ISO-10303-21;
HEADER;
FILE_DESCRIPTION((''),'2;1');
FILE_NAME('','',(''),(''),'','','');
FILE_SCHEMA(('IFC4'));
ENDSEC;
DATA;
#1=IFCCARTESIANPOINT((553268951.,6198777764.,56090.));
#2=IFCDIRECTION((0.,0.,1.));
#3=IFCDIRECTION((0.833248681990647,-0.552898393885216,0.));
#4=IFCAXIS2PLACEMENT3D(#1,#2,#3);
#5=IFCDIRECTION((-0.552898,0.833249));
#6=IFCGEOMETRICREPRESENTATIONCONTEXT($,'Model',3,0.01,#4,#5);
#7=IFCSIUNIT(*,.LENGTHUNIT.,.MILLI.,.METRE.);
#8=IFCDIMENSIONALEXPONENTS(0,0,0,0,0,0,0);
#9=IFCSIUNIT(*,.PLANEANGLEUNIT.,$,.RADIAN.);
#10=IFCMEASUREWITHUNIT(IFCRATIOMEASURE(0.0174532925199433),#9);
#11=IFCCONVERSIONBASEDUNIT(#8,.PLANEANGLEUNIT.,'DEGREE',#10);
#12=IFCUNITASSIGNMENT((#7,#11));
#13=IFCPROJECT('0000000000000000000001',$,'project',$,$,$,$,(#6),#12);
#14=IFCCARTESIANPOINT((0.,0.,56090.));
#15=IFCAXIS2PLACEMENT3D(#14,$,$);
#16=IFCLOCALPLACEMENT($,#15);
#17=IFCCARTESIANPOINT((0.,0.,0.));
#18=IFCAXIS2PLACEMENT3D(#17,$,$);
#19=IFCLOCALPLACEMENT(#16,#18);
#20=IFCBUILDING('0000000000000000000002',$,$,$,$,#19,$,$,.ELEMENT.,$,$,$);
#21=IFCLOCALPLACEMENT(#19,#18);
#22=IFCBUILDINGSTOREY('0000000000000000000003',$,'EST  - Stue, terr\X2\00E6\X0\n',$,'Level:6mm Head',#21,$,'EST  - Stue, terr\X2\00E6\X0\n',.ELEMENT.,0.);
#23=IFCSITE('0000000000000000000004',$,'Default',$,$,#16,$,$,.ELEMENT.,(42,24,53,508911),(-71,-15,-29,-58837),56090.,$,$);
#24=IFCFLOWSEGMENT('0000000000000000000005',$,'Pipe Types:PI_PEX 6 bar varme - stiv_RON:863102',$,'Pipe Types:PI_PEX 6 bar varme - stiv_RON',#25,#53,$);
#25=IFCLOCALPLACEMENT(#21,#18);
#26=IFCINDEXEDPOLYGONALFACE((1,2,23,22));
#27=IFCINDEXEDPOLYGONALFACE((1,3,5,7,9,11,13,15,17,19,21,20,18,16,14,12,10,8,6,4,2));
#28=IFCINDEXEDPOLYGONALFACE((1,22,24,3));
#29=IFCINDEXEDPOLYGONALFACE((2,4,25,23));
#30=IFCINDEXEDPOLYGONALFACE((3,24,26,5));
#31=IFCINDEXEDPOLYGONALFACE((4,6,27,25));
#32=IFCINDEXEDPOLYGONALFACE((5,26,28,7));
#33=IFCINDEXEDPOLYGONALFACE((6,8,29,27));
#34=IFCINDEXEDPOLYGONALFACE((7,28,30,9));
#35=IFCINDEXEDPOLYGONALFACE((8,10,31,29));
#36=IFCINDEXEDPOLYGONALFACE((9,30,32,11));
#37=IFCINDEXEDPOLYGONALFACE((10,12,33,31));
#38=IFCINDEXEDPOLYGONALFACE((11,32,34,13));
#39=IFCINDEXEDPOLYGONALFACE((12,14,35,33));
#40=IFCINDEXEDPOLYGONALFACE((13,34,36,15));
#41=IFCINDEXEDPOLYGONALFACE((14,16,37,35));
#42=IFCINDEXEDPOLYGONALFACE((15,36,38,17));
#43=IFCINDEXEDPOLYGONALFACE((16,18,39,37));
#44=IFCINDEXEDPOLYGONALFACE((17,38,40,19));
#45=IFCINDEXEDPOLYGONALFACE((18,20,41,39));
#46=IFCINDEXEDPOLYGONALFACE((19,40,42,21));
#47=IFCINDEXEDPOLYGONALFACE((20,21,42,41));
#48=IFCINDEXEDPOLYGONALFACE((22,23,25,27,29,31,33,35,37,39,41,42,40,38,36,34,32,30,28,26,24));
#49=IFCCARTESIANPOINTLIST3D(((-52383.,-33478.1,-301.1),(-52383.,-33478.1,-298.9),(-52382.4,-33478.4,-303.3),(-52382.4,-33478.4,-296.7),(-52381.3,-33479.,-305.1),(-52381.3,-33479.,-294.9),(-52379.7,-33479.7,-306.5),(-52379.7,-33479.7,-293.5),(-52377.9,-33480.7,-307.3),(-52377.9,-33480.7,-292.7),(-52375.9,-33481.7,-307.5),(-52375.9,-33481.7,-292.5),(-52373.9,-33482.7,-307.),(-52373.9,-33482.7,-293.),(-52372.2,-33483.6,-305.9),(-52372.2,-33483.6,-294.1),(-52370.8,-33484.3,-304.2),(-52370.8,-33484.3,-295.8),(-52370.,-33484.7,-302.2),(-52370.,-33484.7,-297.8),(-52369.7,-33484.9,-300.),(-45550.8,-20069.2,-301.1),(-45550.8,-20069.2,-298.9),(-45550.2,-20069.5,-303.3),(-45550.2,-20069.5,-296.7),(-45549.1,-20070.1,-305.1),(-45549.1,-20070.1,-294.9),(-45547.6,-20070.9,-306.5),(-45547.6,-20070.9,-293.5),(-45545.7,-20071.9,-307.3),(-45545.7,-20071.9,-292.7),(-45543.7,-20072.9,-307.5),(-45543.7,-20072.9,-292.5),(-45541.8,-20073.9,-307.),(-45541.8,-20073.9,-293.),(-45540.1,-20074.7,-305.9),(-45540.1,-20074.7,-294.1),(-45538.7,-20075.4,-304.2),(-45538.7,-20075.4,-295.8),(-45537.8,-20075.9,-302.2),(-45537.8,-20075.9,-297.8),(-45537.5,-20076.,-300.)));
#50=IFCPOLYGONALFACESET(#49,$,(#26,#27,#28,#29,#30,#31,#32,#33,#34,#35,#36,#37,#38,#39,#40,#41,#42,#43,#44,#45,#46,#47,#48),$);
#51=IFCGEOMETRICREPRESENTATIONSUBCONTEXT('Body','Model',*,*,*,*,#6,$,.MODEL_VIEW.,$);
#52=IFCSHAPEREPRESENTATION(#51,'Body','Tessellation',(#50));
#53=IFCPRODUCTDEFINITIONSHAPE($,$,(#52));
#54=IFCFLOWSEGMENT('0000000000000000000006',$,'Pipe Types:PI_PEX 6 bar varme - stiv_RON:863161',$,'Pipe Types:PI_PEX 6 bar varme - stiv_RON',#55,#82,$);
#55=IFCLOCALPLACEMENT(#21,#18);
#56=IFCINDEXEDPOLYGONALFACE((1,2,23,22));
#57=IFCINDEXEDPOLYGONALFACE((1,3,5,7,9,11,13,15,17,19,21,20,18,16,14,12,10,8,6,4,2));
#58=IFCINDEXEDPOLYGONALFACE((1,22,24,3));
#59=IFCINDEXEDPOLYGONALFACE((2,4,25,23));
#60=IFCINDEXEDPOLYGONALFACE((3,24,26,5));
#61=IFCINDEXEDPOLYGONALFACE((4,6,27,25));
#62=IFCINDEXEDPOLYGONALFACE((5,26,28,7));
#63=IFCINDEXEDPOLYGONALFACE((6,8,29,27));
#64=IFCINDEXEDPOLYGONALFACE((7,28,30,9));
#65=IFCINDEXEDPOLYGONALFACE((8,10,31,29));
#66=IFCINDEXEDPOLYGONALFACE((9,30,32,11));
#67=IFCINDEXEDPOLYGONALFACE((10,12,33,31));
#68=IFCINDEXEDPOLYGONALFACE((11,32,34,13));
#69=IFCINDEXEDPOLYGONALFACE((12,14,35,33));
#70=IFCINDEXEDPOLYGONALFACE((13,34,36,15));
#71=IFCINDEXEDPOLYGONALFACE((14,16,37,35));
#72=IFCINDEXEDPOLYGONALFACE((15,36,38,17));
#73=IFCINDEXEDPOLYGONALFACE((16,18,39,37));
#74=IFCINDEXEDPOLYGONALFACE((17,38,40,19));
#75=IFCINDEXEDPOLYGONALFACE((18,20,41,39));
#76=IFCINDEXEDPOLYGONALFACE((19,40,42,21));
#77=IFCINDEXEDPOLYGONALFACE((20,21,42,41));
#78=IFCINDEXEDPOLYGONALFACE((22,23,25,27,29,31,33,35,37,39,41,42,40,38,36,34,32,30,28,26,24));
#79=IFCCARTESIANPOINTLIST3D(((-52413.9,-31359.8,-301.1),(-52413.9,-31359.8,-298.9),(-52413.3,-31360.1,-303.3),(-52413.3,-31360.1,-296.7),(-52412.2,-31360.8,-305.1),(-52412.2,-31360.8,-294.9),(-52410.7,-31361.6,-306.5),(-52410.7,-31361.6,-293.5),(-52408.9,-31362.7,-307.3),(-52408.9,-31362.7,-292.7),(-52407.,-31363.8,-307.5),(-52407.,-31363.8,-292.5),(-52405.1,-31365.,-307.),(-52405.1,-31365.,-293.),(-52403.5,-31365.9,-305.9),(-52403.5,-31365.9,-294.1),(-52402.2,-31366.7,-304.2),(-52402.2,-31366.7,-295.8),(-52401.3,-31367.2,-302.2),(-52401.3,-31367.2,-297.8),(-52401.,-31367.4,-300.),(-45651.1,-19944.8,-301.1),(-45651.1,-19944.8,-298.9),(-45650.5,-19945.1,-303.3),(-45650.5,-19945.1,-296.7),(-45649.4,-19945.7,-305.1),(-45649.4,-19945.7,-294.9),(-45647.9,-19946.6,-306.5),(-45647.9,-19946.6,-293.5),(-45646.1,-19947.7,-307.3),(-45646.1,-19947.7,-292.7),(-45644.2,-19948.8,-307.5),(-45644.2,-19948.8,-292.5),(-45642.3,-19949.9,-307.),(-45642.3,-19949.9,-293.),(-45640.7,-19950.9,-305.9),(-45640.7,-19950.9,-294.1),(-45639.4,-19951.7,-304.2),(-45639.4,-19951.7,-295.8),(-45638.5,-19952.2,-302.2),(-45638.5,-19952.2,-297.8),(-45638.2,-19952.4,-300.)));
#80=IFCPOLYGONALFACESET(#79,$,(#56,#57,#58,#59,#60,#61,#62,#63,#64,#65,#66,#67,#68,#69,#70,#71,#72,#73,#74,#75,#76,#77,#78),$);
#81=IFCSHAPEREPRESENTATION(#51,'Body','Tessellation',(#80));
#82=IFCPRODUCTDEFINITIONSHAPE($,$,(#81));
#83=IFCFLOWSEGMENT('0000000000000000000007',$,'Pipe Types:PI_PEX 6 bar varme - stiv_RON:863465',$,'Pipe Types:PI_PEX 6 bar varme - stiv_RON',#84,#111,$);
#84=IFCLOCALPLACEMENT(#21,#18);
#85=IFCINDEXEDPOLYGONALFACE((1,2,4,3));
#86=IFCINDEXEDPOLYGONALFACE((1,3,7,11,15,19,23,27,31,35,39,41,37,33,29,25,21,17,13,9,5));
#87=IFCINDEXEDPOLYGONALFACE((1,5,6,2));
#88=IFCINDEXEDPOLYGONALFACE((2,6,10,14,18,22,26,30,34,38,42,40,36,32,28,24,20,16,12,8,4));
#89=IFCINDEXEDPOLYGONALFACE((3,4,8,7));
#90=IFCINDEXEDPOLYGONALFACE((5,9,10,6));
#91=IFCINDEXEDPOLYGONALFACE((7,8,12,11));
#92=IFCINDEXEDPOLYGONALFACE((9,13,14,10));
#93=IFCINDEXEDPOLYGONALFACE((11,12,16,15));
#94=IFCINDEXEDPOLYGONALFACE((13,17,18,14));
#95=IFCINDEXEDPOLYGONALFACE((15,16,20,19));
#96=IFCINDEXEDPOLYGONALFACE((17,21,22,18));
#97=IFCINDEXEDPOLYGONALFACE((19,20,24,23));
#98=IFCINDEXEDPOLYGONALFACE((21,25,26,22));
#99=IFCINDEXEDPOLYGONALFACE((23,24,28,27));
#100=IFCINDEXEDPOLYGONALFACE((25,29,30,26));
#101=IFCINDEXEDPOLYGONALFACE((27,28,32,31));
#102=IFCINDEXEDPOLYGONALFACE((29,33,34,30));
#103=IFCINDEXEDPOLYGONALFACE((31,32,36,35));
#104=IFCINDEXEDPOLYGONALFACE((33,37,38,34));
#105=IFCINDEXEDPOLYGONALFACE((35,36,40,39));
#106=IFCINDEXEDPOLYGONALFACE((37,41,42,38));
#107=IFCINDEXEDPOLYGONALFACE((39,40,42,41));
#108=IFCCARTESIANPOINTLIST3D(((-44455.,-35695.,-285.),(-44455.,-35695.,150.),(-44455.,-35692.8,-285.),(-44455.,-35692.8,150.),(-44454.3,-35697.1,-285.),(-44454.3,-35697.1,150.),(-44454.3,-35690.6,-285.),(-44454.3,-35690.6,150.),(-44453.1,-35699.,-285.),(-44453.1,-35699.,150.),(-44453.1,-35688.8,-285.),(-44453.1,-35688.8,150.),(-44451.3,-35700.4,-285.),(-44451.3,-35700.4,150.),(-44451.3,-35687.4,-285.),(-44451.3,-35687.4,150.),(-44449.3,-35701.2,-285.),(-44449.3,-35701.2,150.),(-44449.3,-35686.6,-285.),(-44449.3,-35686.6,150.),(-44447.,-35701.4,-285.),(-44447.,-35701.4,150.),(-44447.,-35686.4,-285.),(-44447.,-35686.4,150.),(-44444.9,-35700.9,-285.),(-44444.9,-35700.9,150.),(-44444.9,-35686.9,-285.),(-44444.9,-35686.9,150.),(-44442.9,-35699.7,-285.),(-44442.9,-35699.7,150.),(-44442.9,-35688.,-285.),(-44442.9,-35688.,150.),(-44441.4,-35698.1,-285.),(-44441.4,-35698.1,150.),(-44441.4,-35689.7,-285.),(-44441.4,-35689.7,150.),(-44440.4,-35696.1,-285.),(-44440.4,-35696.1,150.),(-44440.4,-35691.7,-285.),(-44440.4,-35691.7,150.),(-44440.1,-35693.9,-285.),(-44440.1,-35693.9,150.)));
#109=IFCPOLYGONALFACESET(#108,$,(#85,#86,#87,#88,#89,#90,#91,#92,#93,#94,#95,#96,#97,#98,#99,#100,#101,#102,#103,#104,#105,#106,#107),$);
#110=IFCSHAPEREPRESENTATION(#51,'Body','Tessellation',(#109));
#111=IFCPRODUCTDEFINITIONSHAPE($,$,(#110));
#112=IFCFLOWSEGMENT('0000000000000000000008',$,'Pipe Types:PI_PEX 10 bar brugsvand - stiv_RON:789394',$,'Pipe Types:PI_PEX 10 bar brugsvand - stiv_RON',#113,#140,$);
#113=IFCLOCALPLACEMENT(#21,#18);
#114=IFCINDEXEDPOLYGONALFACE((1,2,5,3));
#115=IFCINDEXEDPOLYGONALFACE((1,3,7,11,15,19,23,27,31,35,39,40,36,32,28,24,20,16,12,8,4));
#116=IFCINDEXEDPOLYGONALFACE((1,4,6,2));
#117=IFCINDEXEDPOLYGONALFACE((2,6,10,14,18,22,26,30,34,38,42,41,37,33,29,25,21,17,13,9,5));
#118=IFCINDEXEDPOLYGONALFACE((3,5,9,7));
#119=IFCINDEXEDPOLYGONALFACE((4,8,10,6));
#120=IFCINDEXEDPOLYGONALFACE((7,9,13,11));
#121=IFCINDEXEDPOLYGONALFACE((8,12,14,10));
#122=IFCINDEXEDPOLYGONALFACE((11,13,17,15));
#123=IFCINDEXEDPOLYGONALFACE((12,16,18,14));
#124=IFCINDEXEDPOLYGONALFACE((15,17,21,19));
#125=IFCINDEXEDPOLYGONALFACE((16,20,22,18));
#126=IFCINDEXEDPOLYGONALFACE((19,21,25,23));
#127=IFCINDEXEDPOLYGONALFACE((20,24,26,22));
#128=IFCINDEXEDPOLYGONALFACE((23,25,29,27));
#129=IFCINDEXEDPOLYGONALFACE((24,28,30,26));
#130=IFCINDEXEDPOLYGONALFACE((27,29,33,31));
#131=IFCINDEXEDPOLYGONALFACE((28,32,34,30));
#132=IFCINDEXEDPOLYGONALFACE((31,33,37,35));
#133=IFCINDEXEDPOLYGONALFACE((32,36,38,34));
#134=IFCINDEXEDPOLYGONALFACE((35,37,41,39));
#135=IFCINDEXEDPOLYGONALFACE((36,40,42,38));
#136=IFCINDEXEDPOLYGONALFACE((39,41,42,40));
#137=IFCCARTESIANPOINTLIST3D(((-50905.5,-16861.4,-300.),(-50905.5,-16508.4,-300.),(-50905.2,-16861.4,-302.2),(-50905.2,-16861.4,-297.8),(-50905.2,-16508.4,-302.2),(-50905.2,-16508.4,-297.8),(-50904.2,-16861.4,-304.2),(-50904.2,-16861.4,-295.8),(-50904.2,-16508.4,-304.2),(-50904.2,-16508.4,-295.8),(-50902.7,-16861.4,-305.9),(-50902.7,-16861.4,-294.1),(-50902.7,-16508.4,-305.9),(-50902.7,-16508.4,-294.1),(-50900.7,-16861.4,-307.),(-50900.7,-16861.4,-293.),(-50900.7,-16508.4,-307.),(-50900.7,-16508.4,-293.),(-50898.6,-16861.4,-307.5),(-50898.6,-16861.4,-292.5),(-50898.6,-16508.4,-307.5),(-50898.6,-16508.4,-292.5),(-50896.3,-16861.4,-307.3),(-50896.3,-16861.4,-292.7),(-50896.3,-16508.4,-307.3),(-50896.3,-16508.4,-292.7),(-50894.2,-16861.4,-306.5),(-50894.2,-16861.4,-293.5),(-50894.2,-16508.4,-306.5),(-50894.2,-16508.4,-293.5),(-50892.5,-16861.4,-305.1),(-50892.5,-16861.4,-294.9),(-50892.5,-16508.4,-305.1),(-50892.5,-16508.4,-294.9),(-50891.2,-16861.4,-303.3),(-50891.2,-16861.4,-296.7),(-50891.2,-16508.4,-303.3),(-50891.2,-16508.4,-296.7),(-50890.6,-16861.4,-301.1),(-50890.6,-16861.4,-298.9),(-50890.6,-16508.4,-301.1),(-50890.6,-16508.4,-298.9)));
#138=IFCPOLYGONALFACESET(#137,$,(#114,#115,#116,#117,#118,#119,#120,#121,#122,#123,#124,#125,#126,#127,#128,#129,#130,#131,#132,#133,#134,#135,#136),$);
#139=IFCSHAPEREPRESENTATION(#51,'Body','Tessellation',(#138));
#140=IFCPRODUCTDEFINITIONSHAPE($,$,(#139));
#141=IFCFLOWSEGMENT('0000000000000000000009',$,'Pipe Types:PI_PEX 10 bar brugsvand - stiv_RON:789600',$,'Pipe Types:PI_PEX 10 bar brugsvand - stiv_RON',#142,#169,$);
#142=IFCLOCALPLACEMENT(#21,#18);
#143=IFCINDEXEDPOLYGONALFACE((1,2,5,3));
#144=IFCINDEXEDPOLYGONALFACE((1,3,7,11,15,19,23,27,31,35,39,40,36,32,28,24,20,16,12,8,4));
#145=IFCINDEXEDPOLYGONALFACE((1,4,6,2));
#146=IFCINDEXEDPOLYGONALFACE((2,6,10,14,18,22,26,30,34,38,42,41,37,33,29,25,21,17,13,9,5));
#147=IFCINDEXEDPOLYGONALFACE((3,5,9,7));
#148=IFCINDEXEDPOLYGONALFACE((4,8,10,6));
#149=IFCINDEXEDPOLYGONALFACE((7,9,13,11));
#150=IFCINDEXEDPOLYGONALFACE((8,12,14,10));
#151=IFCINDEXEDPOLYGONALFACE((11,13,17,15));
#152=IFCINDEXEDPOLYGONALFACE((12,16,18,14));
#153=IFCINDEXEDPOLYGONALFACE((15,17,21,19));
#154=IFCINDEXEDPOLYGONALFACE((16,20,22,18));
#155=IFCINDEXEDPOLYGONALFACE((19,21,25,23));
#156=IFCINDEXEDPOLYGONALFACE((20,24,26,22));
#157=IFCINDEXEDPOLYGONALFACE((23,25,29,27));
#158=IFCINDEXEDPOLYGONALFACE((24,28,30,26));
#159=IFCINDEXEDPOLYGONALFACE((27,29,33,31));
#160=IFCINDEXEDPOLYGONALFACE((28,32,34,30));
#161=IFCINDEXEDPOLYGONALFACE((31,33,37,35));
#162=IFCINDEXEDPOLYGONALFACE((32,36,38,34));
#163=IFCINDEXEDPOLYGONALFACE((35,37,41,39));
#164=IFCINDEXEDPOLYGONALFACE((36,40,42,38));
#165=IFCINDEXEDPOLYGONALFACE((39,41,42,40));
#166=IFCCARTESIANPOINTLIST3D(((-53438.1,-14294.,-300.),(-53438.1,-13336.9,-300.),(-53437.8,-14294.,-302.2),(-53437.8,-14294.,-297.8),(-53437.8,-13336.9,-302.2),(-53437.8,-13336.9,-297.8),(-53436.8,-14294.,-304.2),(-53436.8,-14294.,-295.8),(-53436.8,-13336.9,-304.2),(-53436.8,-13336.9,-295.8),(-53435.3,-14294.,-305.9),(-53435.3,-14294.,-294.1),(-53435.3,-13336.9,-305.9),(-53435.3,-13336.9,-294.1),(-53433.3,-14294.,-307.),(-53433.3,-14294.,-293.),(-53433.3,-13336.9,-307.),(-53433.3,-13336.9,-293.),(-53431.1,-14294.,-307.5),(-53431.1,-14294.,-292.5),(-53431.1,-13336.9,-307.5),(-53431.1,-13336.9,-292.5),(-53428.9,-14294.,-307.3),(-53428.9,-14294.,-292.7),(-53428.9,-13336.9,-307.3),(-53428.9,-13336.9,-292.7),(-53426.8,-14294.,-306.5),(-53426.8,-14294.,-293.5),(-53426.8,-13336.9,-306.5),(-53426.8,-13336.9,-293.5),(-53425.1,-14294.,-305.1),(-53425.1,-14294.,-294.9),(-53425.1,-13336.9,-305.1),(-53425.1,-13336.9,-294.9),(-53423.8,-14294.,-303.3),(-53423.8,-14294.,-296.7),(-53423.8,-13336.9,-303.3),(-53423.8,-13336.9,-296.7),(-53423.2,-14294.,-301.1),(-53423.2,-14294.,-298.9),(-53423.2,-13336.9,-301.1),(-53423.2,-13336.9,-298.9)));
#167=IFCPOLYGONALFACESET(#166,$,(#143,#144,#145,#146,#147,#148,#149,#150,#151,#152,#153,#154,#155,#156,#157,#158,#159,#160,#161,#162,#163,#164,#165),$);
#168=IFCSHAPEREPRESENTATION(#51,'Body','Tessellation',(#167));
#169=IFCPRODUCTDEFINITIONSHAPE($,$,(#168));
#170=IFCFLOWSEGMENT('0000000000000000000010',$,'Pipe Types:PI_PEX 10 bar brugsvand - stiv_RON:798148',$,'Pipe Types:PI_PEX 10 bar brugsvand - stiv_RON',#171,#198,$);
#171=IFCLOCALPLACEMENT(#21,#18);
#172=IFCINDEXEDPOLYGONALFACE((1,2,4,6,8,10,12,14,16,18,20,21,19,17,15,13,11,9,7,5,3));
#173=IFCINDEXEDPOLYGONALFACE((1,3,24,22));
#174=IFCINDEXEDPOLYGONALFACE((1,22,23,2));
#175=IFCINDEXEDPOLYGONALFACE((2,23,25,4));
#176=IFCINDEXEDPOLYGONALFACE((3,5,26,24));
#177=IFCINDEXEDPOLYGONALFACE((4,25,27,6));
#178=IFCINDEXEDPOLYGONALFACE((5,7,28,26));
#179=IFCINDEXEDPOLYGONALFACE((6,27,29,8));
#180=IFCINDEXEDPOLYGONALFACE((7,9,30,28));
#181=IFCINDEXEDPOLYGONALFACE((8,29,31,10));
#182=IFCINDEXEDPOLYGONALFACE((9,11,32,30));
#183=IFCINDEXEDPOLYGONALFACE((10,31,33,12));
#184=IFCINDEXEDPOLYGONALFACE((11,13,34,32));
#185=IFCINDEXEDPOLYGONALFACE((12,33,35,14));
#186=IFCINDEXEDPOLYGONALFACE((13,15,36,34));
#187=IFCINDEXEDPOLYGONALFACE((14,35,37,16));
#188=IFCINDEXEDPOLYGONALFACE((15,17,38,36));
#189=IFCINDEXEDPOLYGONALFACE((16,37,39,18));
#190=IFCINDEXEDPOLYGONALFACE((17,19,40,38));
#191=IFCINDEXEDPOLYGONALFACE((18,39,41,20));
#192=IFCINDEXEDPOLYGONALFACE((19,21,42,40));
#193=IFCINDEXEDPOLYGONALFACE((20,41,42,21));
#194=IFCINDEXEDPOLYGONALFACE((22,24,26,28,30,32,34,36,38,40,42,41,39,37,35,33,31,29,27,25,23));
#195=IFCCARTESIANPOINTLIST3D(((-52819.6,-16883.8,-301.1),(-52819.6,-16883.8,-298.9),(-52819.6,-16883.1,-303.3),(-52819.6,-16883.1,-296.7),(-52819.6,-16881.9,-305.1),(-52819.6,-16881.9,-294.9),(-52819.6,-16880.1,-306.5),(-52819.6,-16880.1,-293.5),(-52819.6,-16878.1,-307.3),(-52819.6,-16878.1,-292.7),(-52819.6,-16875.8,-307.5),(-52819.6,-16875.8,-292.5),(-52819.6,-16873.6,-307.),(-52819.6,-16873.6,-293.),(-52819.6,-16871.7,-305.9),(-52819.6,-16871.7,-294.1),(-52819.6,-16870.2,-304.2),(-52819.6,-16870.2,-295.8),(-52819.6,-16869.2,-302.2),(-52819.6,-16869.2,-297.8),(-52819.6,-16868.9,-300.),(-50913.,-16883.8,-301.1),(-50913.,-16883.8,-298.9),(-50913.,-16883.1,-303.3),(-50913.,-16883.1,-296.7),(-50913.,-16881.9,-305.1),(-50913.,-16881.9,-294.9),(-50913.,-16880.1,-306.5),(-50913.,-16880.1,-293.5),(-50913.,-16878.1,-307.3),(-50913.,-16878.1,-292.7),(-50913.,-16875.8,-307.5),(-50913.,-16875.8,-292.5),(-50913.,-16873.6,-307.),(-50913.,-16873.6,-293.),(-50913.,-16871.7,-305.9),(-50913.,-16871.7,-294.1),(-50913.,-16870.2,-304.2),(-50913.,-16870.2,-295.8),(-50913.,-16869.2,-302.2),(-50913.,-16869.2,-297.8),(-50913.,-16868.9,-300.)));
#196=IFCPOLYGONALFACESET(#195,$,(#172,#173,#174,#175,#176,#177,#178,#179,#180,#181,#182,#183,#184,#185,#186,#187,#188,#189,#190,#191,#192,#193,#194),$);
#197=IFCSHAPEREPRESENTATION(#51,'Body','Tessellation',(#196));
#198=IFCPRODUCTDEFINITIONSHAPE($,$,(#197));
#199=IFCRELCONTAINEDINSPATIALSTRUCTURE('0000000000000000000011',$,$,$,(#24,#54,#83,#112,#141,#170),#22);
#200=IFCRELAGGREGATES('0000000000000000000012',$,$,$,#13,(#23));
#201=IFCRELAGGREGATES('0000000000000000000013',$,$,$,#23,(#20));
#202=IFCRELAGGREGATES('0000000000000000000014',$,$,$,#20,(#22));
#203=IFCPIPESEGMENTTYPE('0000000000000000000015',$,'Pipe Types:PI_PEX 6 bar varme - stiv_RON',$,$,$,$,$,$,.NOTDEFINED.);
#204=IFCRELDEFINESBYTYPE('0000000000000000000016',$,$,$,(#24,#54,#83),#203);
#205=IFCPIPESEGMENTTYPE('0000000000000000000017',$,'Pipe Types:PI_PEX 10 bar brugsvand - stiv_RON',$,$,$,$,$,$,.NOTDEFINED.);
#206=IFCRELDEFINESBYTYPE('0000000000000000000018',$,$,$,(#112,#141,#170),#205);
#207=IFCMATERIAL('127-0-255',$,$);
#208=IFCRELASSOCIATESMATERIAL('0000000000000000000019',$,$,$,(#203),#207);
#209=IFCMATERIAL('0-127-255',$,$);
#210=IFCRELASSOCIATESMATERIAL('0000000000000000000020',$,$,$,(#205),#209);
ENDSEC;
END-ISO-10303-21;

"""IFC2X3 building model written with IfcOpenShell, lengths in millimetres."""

from ifc_helpers import new_model, entity, si_unit, converted_unit, direction, frame, frame_2d, origin, origin_2d_with_axis, place, context, subcontext, project, spatial, circle, extrude, material, type_object, element, save


model = new_model("IFC2X3")

# Units and contexts
model_context = context("Model", 3, precision=0.01, world=frame((553268951.0, 6198777764.0, 56090.0), z_axis=(0.0, 0.0, 1.0), x_axis=(0.833248681990647, -0.552898393885216, 0.0)), true_north=direction((-0.552898, 0.833249)))
body_context = subcontext(model_context, "Body", "Model", "MODEL_VIEW")
ifc_project = project(units=[si_unit("LENGTHUNIT", "METRE", prefix="MILLI"), converted_unit("PLANEANGLEUNIT", "DEGREE", entity("IfcRatioMeasure", 0.0174532925199433), si_unit("PLANEANGLEUNIT", "RADIAN"), dimensions=[0, 0, 0, 0, 0, 0, 0])], contexts=[model_context])

# Site, building, storey
site_placement = place(None, frame((0.0, 0.0, 56090.0)))
site = spatial("IfcSite", under=ifc_project, at=site_placement, Name="Default", CompositionType="ELEMENT", RefLatitude=(42, 24, 53, 508911), RefLongitude=(-71, -15, -29, -58837), RefElevation=56090.0)
building_placement = place(site_placement, origin())
building = spatial("IfcBuilding", under=site, at=building_placement, CompositionType="ELEMENT")
storey_placement = place(building_placement, frame((0.0, 0.0, 0.0)))
storey = spatial("IfcBuildingStorey", under=building, at=storey_placement, Name="EST  - Stue, terræn", ObjectType="Level:6mm Head", LongName="EST  - Stue, terræn", CompositionType="ELEMENT", Elevation=0.0)

# Flow segments
ifc_material_1 = material(Name="127-0-255")
pipe_segment_type_1 = type_object("IfcPipeSegmentType", Name="Pipe Types:PI_PEX 6 bar varme - stiv_RON", PredefinedType="NOTDEFINED", material=ifc_material_1)
flow_segment_1_placement = place(storey_placement, origin())
element("IfcFlowSegment", 1, at=flow_segment_1_placement, inside=storey, type_object=pipe_segment_type_1, Name="Pipe Types:PI_PEX 6 bar varme - stiv_RON:863102", ObjectType="Pipe Types:PI_PEX 6 bar varme - stiv_RON", context=body_context, shape_type="SweptSolid", body=[
    extrude(circle(Radius=7.5, at=origin_2d_with_axis()), frame((-52376.4, -33481.5, -300.0), z_axis=(0.45399, 0.891007, 0.0), x_axis=(0.891007, -0.45399, 0.0)), (0.0, 0.0, 1.0), 15049.1),
])
flow_segment_2_placement = place(storey_placement, origin())
element("IfcFlowSegment", 2, at=flow_segment_2_placement, inside=storey, type_object=pipe_segment_type_1, Name="Pipe Types:PI_PEX 6 bar varme - stiv_RON:863161", ObjectType="Pipe Types:PI_PEX 6 bar varme - stiv_RON", context=body_context, shape_type="SweptSolid", body=[
    extrude(circle(Radius=7.5, at=frame_2d((0.0, 0.0), x_axis=(1.0, 0.0))), frame((-52407.5, -31363.6, -300.0), z_axis=(0.509711, 0.860346, 0.0), x_axis=(0.860346, -0.509711, 0.0)), (0.0, 0.0, 1.0), 13267.9),
])
flow_segment_3_placement = place(storey_placement, origin())
element("IfcFlowSegment", 3, at=flow_segment_3_placement, inside=storey, type_object=pipe_segment_type_1, Name="Pipe Types:PI_PEX 6 bar varme - stiv_RON:863465", ObjectType="Pipe Types:PI_PEX 6 bar varme - stiv_RON", context=body_context, shape_type="SweptSolid", body=[
    extrude(circle(Radius=7.5, at=origin_2d_with_axis()), frame((-44447.6, -35693.9, -285.0)), (0.0, 0.0, 1.0), 435.0),
])
ifc_material_2 = material(Name="0-127-255")
pipe_segment_type_2 = type_object("IfcPipeSegmentType", Name="Pipe Types:PI_PEX 10 bar brugsvand - stiv_RON", PredefinedType="NOTDEFINED", material=ifc_material_2)
flow_segment_4_placement = place(storey_placement, origin())
element("IfcFlowSegment", 4, at=flow_segment_4_placement, inside=storey, type_object=pipe_segment_type_2, Name="Pipe Types:PI_PEX 10 bar brugsvand - stiv_RON:789394", ObjectType="Pipe Types:PI_PEX 10 bar brugsvand - stiv_RON", context=body_context, shape_type="SweptSolid", body=[
    extrude(circle(Radius=7.5, at=frame_2d((0.0, 0.0), x_axis=(1.0, 0.0))), frame((-50898.0, -16861.4, -300.0), z_axis=(0.0, 1.0, 0.0), x_axis=(-1.0, 0.0, 0.0)), (0.0, 0.0, 1.0), 353.0),
])
flow_segment_5_placement = place(storey_placement, origin())
element("IfcFlowSegment", 5, at=flow_segment_5_placement, inside=storey, type_object=pipe_segment_type_2, Name="Pipe Types:PI_PEX 10 bar brugsvand - stiv_RON:789600", ObjectType="Pipe Types:PI_PEX 10 bar brugsvand - stiv_RON", context=body_context, shape_type="SweptSolid", body=[
    extrude(circle(Radius=7.5, at=origin_2d_with_axis()), frame((-53430.6, -14294.0, -300.0), z_axis=(0.0, 1.0, 0.0), x_axis=(-1.0, 0.0, 0.0)), (0.0, 0.0, 1.0), 957.1),
])
flow_segment_6_placement = place(storey_placement, origin())
element("IfcFlowSegment", 6, at=flow_segment_6_placement, inside=storey, type_object=pipe_segment_type_2, Name="Pipe Types:PI_PEX 10 bar brugsvand - stiv_RON:798148", ObjectType="Pipe Types:PI_PEX 10 bar brugsvand - stiv_RON", context=body_context, shape_type="SweptSolid", body=[
    extrude(circle(Radius=7.5, at=frame_2d((0.0, 0.0), x_axis=(1.0, 0.0))), frame((-52819.6, -16876.4, -300.0), z_axis=(1.0, 0.0, 0.0), x_axis=(0.0, 1.0, 0.0)), (0.0, 0.0, 1.0), 1906.6),
])

save(model, "model.ifc")
